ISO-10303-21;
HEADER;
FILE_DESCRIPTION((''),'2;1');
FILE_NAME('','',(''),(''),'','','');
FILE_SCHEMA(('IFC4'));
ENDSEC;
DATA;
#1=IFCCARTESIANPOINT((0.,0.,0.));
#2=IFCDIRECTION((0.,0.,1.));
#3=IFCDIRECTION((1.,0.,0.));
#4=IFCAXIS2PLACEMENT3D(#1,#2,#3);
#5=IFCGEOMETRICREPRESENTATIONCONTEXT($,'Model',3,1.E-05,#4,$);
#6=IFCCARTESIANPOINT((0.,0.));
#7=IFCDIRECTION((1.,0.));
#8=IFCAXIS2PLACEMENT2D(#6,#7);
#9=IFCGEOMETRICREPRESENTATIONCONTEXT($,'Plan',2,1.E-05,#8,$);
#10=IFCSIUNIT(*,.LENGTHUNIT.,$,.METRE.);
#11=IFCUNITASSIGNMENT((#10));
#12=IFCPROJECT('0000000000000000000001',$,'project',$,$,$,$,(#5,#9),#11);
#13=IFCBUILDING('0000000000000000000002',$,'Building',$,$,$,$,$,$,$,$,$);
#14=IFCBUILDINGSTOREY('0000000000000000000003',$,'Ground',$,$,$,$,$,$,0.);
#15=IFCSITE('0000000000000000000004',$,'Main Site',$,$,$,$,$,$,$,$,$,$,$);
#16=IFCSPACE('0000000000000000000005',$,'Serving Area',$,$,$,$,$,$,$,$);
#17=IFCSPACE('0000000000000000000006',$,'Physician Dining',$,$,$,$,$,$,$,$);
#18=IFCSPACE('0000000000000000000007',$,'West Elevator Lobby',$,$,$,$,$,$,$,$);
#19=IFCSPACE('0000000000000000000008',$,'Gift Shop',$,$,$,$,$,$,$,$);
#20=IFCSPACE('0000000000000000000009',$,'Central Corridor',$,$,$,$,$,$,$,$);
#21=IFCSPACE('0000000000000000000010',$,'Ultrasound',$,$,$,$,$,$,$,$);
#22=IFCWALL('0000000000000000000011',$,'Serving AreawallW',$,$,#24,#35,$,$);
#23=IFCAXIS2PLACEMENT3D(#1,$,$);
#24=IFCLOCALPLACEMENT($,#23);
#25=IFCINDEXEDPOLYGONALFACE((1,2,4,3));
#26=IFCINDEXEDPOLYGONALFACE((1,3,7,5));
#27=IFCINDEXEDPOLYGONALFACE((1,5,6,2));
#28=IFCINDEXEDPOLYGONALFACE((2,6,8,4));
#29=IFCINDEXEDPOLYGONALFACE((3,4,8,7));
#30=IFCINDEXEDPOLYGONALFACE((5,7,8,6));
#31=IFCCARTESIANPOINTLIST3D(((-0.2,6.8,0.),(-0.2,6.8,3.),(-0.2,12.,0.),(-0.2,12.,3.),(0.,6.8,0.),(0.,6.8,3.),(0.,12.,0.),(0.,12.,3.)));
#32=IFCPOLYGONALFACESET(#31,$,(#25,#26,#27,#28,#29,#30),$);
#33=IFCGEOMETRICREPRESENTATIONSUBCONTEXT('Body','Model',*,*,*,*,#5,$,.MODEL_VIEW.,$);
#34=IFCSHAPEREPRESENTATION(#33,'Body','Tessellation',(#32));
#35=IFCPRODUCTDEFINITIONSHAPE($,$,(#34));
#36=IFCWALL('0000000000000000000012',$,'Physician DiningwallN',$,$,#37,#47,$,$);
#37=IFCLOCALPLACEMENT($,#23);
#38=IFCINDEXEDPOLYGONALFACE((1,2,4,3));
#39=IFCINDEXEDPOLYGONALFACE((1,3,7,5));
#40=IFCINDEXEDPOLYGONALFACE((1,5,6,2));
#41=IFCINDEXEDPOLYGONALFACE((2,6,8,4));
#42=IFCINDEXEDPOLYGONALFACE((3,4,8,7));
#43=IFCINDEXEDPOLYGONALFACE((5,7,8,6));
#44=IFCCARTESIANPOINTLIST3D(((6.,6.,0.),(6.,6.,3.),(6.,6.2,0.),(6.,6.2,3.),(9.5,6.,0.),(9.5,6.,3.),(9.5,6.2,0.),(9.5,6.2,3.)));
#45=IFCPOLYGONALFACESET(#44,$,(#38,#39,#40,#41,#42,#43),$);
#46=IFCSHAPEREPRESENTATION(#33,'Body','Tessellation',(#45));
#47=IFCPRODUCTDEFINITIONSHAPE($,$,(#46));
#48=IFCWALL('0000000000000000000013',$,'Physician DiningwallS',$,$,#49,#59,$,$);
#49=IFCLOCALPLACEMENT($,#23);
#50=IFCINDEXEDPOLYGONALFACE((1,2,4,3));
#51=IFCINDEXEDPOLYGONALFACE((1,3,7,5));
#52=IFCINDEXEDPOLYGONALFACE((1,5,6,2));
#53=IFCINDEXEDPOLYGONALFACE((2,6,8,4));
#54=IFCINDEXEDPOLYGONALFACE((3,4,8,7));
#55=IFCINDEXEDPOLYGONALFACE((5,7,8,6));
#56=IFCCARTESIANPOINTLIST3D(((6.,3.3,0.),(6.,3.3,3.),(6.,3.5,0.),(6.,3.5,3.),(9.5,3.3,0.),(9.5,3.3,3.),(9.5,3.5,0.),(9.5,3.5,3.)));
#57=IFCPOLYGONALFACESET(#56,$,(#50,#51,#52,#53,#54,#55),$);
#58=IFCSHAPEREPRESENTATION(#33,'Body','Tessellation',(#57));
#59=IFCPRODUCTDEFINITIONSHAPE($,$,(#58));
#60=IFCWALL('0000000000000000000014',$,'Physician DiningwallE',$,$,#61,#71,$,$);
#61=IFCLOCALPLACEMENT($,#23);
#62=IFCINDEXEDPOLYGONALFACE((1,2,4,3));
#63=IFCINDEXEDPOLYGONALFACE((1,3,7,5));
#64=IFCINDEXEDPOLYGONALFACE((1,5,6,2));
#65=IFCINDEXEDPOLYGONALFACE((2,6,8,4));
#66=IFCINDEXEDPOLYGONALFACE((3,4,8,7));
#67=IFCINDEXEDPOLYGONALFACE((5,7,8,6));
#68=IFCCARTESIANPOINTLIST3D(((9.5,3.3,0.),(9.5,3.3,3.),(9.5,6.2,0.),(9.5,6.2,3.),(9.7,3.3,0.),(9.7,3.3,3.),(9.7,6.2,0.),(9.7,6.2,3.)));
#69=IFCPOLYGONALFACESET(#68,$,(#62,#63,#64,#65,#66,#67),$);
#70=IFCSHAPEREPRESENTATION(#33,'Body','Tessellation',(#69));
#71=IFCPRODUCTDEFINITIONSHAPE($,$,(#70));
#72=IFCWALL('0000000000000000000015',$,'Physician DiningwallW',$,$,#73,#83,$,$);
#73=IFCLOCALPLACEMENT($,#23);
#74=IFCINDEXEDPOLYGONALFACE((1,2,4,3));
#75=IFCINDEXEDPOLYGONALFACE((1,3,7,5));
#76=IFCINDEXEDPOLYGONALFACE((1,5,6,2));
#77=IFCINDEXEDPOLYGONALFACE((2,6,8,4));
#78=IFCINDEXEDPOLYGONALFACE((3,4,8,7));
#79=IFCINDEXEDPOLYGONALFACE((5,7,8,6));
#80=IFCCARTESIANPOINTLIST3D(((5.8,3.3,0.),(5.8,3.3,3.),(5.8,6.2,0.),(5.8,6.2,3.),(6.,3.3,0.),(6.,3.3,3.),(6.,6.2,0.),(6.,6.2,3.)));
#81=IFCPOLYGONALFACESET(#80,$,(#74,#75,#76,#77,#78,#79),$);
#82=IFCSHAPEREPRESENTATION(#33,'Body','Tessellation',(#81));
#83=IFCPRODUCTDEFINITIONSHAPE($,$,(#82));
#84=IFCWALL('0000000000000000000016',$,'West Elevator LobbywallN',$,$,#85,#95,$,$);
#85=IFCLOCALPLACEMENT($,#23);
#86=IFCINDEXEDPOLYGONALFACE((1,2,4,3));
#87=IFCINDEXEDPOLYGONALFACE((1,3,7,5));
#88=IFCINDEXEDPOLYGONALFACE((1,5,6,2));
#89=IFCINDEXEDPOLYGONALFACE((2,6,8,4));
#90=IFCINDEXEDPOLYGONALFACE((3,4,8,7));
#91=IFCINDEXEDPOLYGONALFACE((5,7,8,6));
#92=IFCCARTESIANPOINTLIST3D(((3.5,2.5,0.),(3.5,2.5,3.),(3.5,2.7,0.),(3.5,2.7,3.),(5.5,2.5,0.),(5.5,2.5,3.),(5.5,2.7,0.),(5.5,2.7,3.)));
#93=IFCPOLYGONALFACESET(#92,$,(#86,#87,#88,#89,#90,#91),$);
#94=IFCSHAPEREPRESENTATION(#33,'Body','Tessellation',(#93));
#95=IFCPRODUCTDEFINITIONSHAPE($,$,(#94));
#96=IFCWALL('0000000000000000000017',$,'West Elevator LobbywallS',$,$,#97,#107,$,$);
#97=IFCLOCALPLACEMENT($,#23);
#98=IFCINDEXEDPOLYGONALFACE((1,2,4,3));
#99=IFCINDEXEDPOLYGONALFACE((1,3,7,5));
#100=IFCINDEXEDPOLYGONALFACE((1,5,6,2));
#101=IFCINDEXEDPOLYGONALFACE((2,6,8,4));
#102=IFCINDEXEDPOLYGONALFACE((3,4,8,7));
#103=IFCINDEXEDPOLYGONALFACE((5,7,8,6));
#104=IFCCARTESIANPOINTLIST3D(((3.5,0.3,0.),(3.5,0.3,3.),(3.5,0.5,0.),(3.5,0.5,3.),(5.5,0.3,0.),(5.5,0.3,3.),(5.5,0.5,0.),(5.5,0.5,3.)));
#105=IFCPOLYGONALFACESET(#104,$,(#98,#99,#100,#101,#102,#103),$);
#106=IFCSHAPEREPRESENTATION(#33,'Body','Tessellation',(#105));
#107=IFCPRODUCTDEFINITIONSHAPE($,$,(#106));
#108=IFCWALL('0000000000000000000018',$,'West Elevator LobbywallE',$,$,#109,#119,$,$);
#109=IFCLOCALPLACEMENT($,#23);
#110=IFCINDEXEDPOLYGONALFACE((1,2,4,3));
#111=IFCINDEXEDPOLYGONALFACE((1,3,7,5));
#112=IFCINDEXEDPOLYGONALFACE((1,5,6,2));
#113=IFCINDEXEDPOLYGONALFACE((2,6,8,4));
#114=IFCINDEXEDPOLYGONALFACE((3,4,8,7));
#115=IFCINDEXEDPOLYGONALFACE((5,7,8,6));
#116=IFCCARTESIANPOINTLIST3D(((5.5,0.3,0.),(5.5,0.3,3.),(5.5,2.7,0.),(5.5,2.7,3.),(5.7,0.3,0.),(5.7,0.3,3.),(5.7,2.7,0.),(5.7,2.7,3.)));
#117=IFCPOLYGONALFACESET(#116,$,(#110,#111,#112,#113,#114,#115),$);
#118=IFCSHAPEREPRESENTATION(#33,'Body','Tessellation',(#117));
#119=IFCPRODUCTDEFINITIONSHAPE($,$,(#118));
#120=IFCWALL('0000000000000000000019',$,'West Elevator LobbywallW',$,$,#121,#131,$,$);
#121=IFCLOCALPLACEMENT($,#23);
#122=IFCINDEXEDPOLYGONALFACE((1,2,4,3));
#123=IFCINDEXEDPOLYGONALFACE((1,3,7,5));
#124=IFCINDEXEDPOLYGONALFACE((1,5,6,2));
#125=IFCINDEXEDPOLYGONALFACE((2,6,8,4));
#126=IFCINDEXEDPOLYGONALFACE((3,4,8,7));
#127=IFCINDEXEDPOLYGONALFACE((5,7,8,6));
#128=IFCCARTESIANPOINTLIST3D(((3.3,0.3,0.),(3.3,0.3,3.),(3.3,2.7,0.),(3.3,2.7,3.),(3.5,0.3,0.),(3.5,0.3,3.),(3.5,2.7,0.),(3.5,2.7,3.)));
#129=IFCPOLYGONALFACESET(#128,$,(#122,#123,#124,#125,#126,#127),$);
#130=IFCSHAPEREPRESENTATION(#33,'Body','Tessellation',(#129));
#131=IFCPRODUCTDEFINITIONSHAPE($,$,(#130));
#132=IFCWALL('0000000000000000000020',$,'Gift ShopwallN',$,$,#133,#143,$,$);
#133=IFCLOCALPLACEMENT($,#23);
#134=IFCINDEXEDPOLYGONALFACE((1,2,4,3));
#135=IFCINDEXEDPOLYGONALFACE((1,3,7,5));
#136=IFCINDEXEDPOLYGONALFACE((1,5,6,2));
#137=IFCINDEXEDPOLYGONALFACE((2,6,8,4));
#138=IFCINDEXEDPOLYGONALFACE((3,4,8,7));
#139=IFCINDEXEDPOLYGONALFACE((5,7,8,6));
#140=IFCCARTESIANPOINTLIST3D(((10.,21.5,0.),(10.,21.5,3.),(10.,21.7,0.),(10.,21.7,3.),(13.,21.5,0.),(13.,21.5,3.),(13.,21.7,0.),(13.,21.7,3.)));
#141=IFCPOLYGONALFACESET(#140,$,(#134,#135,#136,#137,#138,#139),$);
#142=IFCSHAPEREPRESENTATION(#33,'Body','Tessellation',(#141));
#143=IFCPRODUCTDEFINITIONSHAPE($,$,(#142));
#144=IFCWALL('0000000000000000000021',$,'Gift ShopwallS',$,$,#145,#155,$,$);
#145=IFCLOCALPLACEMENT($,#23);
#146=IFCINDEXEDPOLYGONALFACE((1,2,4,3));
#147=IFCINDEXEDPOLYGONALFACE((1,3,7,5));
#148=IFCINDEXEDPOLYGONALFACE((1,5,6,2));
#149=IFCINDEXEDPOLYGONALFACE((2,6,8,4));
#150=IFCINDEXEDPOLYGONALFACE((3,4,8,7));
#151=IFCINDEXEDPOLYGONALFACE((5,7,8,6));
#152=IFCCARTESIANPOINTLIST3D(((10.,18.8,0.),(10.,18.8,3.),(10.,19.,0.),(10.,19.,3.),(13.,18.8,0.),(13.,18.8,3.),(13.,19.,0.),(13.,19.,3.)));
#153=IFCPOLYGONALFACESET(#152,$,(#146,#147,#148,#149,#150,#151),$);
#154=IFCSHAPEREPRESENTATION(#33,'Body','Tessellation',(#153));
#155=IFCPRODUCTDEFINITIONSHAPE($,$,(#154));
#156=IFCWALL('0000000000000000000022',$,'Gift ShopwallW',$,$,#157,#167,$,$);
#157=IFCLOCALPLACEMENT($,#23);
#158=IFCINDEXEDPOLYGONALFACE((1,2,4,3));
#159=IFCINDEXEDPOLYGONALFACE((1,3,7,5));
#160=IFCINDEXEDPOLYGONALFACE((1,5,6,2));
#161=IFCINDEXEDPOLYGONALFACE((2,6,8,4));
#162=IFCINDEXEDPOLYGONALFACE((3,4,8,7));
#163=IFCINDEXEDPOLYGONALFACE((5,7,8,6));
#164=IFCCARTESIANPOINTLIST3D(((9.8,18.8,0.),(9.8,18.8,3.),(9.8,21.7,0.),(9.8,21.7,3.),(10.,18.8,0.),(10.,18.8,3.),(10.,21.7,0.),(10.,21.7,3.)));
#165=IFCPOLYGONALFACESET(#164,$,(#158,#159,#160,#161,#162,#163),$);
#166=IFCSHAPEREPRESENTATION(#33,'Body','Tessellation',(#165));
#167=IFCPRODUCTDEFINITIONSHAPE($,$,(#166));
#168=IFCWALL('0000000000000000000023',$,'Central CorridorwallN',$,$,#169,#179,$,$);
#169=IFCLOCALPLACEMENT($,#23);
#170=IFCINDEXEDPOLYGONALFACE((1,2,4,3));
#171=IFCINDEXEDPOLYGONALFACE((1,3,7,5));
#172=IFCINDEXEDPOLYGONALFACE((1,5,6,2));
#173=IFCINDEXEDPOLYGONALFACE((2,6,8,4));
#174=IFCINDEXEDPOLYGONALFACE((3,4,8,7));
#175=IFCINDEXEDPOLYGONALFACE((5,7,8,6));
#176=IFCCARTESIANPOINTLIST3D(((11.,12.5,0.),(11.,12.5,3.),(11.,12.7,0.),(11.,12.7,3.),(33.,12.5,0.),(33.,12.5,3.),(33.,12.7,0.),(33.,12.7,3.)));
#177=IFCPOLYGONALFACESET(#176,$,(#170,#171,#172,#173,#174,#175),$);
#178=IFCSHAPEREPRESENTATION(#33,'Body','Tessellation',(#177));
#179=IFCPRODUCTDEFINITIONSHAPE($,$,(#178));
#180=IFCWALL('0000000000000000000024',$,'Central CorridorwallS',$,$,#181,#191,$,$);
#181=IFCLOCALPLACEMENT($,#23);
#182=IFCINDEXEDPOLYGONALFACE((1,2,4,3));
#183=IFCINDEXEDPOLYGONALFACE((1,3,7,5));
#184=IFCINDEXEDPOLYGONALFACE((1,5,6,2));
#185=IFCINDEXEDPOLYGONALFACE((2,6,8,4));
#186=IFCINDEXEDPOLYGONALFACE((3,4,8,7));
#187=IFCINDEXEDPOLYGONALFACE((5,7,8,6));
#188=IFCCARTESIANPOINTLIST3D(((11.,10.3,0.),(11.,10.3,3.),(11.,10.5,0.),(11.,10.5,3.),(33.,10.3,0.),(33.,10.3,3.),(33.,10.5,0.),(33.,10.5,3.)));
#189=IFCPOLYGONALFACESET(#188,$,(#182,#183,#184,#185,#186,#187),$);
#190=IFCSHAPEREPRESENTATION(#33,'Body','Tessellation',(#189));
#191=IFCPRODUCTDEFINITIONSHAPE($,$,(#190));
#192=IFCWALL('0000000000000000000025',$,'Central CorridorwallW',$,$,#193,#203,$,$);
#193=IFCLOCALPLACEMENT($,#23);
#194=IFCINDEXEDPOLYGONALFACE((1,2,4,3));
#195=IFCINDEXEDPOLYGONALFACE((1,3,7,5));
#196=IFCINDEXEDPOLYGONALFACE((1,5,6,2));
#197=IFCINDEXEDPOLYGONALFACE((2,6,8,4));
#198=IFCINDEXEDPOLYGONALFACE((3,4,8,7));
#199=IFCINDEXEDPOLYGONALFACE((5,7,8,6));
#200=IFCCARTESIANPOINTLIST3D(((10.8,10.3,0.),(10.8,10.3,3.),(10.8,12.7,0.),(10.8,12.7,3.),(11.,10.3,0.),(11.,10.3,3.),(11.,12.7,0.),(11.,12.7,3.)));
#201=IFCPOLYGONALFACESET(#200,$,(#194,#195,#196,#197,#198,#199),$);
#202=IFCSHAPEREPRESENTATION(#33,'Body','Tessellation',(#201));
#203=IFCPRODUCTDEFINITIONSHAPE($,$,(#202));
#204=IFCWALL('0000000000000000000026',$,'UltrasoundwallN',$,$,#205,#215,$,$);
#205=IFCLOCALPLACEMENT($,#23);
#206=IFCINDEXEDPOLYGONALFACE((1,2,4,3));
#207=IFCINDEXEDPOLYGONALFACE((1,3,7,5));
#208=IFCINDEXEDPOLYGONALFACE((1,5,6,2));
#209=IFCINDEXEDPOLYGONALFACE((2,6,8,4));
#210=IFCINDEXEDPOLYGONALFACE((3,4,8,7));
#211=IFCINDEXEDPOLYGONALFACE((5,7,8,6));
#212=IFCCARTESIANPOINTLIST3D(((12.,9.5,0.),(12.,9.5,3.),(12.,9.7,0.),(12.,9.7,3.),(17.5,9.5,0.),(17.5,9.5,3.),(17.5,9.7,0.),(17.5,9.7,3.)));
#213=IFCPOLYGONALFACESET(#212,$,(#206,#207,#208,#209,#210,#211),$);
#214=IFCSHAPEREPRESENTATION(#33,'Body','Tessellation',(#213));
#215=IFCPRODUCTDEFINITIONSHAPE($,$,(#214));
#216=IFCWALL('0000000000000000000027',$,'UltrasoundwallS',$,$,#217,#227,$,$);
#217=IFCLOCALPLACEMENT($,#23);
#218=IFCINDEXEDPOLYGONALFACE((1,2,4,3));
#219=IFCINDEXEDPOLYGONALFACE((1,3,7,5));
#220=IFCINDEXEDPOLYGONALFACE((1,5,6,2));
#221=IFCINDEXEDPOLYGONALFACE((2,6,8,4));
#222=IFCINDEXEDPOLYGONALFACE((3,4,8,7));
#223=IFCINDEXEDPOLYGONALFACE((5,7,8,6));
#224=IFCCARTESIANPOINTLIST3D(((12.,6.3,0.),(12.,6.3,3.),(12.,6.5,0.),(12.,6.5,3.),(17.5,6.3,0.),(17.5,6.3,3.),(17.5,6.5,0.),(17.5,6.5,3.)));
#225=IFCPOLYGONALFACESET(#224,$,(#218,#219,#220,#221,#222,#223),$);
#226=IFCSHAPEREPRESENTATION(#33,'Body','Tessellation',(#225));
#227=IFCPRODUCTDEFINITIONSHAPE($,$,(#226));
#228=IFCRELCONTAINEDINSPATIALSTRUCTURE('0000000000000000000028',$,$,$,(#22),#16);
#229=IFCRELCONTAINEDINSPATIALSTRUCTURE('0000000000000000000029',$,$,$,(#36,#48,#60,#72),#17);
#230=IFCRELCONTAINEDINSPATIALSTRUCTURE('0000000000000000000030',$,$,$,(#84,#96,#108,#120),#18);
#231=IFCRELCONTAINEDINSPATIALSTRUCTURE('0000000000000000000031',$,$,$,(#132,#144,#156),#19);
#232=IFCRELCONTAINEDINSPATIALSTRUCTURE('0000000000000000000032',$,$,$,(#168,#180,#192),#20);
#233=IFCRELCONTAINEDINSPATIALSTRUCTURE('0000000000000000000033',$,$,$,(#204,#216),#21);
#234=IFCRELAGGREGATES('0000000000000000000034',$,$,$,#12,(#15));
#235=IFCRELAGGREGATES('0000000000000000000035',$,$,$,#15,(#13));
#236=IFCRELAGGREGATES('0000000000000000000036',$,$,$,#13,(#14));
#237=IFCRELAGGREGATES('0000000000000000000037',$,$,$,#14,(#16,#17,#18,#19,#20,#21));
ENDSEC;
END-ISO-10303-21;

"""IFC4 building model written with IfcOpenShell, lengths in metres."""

from ifc_helpers import new_model, si_unit, frame, origin_with_axes, origin_2d_with_axis, place, context, subcontext, project, spatial, indexed_curve, outline, extrude, element, save


model = new_model("IFC4")

# Units and contexts
model_context = context("Model", 3, precision=1e-05, world=origin_with_axes())
plan_context = context("Plan", 2, precision=1e-05, world=origin_2d_with_axis())
body_context = subcontext(model_context, "Body", "Model", "MODEL_VIEW")
ifc_project = project(units=[si_unit("LENGTHUNIT", "METRE")], contexts=[model_context, plan_context])

# Site, building, storey
site = spatial("IfcSite", under=ifc_project, Name="Main Site")
building = spatial("IfcBuilding", under=site, Name="Building")
storey = spatial("IfcBuildingStorey", under=building, Name="Ground", Elevation=0.0)

# Shared definitions
space_1 = spatial("IfcSpace", under=storey, Name="Serving Area")

# Shared definitions
space_2 = spatial("IfcSpace", under=storey, Name="Physician Dining")

# Shared definitions
space_3 = spatial("IfcSpace", under=storey, Name="West Elevator Lobby")

# Shared definitions
space_4 = spatial("IfcSpace", under=storey, Name="Gift Shop")

# Walls
for number, where, z_axis, x_axis, name in (
    (1, (0.0, 6.8, 0.0), (0.0, 0.0, 1.0), (0.0, 1.0, 0.0), "Serving AreawallW"),
):
    element("IfcWall", number, at=place(None, frame(where, z_axis=z_axis, x_axis=x_axis)), inside=space_1, Name=name, context=body_context, shape_type="SweptSolid", body=[
        extrude(outline(indexed_curve([(0.0, 0.0), (0.0, 0.2), (5.2, 0.2), (5.2, 0.0), (0.0, 0.0)], self_intersect=False)), origin_with_axes(), (0.0, 0.0, 1.0), 3.0),
    ])
for number, where, z_axis, x_axis, name in (
    (2, (6.0, 6.0, 0.0), (0.0, 0.0, 1.0), (1.0, 0.0, 0.0), "Physician DiningwallN"),
    (3, (6.0, 3.3, 0.0), (0.0, 0.0, 1.0), (1.0, 0.0, 0.0), "Physician DiningwallS"),
):
    element("IfcWall", number, at=place(None, frame(where, z_axis=z_axis, x_axis=x_axis)), inside=space_2, Name=name, context=body_context, shape_type="SweptSolid", body=[
        extrude(outline(indexed_curve([(0.0, 0.0), (0.0, 0.2), (3.5, 0.2), (3.5, 0.0), (0.0, 0.0)], self_intersect=False)), origin_with_axes(), (0.0, 0.0, 1.0), 3.0),
    ])
for number, where, z_axis, x_axis, name in (
    (4, (9.7, 3.3, 0.0), (0.0, 0.0, 1.0), (0.0, 1.0, 0.0), "Physician DiningwallE"),
    (5, (6.0, 3.3, 0.0), (0.0, 0.0, 1.0), (0.0, 1.0, 0.0), "Physician DiningwallW"),
):
    element("IfcWall", number, at=place(None, frame(where, z_axis=z_axis, x_axis=x_axis)), inside=space_2, Name=name, context=body_context, shape_type="SweptSolid", body=[
        extrude(outline(indexed_curve([(0.0, 0.0), (0.0, 0.2), (2.9, 0.2), (2.9, 0.0), (0.0, 0.0)], self_intersect=False)), origin_with_axes(), (0.0, 0.0, 1.0), 3.0),
    ])
for number, where, z_axis, x_axis, name in (
    (6, (3.5, 2.5, 0.0), (0.0, 0.0, 1.0), (1.0, 0.0, 0.0), "West Elevator LobbywallN"),
    (7, (3.5, 0.3, 0.0), (0.0, 0.0, 1.0), (1.0, 0.0, 0.0), "West Elevator LobbywallS"),
):
    element("IfcWall", number, at=place(None, frame(where, z_axis=z_axis, x_axis=x_axis)), inside=space_3, Name=name, context=body_context, shape_type="SweptSolid", body=[
        extrude(outline(indexed_curve([(0.0, 0.0), (0.0, 0.2), (2.0, 0.2), (2.0, 0.0), (0.0, 0.0)], self_intersect=False)), origin_with_axes(), (0.0, 0.0, 1.0), 3.0),
    ])
for number, where, z_axis, x_axis, name in (
    (8, (5.7, 0.3, 0.0), (0.0, 0.0, 1.0), (0.0, 1.0, 0.0), "West Elevator LobbywallE"),
    (9, (3.5, 0.3, 0.0), (0.0, 0.0, 1.0), (0.0, 1.0, 0.0), "West Elevator LobbywallW"),
):
    element("IfcWall", number, at=place(None, frame(where, z_axis=z_axis, x_axis=x_axis)), inside=space_3, Name=name, context=body_context, shape_type="SweptSolid", body=[
        extrude(outline(indexed_curve([(0.0, 0.0), (0.0, 0.2), (2.4, 0.2), (2.4, 0.0), (0.0, 0.0)], self_intersect=False)), origin_with_axes(), (0.0, 0.0, 1.0), 3.0),
    ])
for number, where, z_axis, x_axis, name in (
    (10, (10.0, 21.5, 0.0), (0.0, 0.0, 1.0), (1.0, 0.0, 0.0), "Gift ShopwallN"),
    (11, (10.0, 18.8, 0.0), (0.0, 0.0, 1.0), (1.0, 0.0, 0.0), "Gift ShopwallS"),
):
    element("IfcWall", number, at=place(None, frame(where, z_axis=z_axis, x_axis=x_axis)), inside=space_4, Name=name, context=body_context, shape_type="SweptSolid", body=[
        extrude(outline(indexed_curve([(0.0, 0.0), (0.0, 0.2), (3.0, 0.2), (3.0, 0.0), (0.0, 0.0)], self_intersect=False)), origin_with_axes(), (0.0, 0.0, 1.0), 3.0),
    ])
wall_1_placement = place(None, frame((10.0, 18.8, 0.0), z_axis=(0.0, 0.0, 1.0), x_axis=(0.0, 1.0, 0.0)))
element("IfcWall", 12, at=wall_1_placement, inside=space_4, Name="Gift ShopwallW", context=body_context, shape_type="SweptSolid", body=[
    extrude(outline(indexed_curve([(0.0, 0.0), (0.0, 0.2), (2.9, 0.2), (2.9, 0.0), (0.0, 0.0)], self_intersect=False)), origin_with_axes(), (0.0, 0.0, 1.0), 3.0),
])

# Shared definitions
space_5 = spatial("IfcSpace", under=storey, Name="Central Corridor")

# Walls
for number, where, z_axis, x_axis, name in (
    (13, (11.0, 12.5, 0.0), (0.0, 0.0, 1.0), (1.0, 0.0, 0.0), "Central CorridorwallN"),
    (14, (11.0, 10.3, 0.0), (0.0, 0.0, 1.0), (1.0, 0.0, 0.0), "Central CorridorwallS"),
):
    element("IfcWall", number, at=place(None, frame(where, z_axis=z_axis, x_axis=x_axis)), inside=space_5, Name=name, context=body_context, shape_type="SweptSolid", body=[
        extrude(outline(indexed_curve([(0.0, 0.0), (0.0, 0.2), (22.0, 0.2), (22.0, 0.0), (0.0, 0.0)], self_intersect=False)), origin_with_axes(), (0.0, 0.0, 1.0), 3.0),
    ])
wall_2_placement = place(None, frame((11.0, 10.3, 0.0), z_axis=(0.0, 0.0, 1.0), x_axis=(0.0, 1.0, 0.0)))
element("IfcWall", 15, at=wall_2_placement, inside=space_5, Name="Central CorridorwallW", context=body_context, shape_type="SweptSolid", body=[
    extrude(outline(indexed_curve([(0.0, 0.0), (0.0, 0.2), (2.4, 0.2), (2.4, 0.0), (0.0, 0.0)], self_intersect=False)), origin_with_axes(), (0.0, 0.0, 1.0), 3.0),
])

# Shared definitions
space_6 = spatial("IfcSpace", under=storey, Name="Ultrasound")

# Walls
for number, where, z_axis, x_axis, name in (
    (16, (12.0, 9.5, 0.0), (0.0, 0.0, 1.0), (1.0, 0.0, 0.0), "UltrasoundwallN"),
    (17, (12.0, 6.3, 0.0), (0.0, 0.0, 1.0), (1.0, 0.0, 0.0), "UltrasoundwallS"),
):
    element("IfcWall", number, at=place(None, frame(where, z_axis=z_axis, x_axis=x_axis)), inside=space_6, Name=name, context=body_context, shape_type="SweptSolid", body=[
        extrude(outline(indexed_curve([(0.0, 0.0), (0.0, 0.2), (5.5, 0.2), (5.5, 0.0), (0.0, 0.0)], self_intersect=False)), origin_with_axes(), (0.0, 0.0, 1.0), 3.0),
    ])

save(model, "model.ifc")
